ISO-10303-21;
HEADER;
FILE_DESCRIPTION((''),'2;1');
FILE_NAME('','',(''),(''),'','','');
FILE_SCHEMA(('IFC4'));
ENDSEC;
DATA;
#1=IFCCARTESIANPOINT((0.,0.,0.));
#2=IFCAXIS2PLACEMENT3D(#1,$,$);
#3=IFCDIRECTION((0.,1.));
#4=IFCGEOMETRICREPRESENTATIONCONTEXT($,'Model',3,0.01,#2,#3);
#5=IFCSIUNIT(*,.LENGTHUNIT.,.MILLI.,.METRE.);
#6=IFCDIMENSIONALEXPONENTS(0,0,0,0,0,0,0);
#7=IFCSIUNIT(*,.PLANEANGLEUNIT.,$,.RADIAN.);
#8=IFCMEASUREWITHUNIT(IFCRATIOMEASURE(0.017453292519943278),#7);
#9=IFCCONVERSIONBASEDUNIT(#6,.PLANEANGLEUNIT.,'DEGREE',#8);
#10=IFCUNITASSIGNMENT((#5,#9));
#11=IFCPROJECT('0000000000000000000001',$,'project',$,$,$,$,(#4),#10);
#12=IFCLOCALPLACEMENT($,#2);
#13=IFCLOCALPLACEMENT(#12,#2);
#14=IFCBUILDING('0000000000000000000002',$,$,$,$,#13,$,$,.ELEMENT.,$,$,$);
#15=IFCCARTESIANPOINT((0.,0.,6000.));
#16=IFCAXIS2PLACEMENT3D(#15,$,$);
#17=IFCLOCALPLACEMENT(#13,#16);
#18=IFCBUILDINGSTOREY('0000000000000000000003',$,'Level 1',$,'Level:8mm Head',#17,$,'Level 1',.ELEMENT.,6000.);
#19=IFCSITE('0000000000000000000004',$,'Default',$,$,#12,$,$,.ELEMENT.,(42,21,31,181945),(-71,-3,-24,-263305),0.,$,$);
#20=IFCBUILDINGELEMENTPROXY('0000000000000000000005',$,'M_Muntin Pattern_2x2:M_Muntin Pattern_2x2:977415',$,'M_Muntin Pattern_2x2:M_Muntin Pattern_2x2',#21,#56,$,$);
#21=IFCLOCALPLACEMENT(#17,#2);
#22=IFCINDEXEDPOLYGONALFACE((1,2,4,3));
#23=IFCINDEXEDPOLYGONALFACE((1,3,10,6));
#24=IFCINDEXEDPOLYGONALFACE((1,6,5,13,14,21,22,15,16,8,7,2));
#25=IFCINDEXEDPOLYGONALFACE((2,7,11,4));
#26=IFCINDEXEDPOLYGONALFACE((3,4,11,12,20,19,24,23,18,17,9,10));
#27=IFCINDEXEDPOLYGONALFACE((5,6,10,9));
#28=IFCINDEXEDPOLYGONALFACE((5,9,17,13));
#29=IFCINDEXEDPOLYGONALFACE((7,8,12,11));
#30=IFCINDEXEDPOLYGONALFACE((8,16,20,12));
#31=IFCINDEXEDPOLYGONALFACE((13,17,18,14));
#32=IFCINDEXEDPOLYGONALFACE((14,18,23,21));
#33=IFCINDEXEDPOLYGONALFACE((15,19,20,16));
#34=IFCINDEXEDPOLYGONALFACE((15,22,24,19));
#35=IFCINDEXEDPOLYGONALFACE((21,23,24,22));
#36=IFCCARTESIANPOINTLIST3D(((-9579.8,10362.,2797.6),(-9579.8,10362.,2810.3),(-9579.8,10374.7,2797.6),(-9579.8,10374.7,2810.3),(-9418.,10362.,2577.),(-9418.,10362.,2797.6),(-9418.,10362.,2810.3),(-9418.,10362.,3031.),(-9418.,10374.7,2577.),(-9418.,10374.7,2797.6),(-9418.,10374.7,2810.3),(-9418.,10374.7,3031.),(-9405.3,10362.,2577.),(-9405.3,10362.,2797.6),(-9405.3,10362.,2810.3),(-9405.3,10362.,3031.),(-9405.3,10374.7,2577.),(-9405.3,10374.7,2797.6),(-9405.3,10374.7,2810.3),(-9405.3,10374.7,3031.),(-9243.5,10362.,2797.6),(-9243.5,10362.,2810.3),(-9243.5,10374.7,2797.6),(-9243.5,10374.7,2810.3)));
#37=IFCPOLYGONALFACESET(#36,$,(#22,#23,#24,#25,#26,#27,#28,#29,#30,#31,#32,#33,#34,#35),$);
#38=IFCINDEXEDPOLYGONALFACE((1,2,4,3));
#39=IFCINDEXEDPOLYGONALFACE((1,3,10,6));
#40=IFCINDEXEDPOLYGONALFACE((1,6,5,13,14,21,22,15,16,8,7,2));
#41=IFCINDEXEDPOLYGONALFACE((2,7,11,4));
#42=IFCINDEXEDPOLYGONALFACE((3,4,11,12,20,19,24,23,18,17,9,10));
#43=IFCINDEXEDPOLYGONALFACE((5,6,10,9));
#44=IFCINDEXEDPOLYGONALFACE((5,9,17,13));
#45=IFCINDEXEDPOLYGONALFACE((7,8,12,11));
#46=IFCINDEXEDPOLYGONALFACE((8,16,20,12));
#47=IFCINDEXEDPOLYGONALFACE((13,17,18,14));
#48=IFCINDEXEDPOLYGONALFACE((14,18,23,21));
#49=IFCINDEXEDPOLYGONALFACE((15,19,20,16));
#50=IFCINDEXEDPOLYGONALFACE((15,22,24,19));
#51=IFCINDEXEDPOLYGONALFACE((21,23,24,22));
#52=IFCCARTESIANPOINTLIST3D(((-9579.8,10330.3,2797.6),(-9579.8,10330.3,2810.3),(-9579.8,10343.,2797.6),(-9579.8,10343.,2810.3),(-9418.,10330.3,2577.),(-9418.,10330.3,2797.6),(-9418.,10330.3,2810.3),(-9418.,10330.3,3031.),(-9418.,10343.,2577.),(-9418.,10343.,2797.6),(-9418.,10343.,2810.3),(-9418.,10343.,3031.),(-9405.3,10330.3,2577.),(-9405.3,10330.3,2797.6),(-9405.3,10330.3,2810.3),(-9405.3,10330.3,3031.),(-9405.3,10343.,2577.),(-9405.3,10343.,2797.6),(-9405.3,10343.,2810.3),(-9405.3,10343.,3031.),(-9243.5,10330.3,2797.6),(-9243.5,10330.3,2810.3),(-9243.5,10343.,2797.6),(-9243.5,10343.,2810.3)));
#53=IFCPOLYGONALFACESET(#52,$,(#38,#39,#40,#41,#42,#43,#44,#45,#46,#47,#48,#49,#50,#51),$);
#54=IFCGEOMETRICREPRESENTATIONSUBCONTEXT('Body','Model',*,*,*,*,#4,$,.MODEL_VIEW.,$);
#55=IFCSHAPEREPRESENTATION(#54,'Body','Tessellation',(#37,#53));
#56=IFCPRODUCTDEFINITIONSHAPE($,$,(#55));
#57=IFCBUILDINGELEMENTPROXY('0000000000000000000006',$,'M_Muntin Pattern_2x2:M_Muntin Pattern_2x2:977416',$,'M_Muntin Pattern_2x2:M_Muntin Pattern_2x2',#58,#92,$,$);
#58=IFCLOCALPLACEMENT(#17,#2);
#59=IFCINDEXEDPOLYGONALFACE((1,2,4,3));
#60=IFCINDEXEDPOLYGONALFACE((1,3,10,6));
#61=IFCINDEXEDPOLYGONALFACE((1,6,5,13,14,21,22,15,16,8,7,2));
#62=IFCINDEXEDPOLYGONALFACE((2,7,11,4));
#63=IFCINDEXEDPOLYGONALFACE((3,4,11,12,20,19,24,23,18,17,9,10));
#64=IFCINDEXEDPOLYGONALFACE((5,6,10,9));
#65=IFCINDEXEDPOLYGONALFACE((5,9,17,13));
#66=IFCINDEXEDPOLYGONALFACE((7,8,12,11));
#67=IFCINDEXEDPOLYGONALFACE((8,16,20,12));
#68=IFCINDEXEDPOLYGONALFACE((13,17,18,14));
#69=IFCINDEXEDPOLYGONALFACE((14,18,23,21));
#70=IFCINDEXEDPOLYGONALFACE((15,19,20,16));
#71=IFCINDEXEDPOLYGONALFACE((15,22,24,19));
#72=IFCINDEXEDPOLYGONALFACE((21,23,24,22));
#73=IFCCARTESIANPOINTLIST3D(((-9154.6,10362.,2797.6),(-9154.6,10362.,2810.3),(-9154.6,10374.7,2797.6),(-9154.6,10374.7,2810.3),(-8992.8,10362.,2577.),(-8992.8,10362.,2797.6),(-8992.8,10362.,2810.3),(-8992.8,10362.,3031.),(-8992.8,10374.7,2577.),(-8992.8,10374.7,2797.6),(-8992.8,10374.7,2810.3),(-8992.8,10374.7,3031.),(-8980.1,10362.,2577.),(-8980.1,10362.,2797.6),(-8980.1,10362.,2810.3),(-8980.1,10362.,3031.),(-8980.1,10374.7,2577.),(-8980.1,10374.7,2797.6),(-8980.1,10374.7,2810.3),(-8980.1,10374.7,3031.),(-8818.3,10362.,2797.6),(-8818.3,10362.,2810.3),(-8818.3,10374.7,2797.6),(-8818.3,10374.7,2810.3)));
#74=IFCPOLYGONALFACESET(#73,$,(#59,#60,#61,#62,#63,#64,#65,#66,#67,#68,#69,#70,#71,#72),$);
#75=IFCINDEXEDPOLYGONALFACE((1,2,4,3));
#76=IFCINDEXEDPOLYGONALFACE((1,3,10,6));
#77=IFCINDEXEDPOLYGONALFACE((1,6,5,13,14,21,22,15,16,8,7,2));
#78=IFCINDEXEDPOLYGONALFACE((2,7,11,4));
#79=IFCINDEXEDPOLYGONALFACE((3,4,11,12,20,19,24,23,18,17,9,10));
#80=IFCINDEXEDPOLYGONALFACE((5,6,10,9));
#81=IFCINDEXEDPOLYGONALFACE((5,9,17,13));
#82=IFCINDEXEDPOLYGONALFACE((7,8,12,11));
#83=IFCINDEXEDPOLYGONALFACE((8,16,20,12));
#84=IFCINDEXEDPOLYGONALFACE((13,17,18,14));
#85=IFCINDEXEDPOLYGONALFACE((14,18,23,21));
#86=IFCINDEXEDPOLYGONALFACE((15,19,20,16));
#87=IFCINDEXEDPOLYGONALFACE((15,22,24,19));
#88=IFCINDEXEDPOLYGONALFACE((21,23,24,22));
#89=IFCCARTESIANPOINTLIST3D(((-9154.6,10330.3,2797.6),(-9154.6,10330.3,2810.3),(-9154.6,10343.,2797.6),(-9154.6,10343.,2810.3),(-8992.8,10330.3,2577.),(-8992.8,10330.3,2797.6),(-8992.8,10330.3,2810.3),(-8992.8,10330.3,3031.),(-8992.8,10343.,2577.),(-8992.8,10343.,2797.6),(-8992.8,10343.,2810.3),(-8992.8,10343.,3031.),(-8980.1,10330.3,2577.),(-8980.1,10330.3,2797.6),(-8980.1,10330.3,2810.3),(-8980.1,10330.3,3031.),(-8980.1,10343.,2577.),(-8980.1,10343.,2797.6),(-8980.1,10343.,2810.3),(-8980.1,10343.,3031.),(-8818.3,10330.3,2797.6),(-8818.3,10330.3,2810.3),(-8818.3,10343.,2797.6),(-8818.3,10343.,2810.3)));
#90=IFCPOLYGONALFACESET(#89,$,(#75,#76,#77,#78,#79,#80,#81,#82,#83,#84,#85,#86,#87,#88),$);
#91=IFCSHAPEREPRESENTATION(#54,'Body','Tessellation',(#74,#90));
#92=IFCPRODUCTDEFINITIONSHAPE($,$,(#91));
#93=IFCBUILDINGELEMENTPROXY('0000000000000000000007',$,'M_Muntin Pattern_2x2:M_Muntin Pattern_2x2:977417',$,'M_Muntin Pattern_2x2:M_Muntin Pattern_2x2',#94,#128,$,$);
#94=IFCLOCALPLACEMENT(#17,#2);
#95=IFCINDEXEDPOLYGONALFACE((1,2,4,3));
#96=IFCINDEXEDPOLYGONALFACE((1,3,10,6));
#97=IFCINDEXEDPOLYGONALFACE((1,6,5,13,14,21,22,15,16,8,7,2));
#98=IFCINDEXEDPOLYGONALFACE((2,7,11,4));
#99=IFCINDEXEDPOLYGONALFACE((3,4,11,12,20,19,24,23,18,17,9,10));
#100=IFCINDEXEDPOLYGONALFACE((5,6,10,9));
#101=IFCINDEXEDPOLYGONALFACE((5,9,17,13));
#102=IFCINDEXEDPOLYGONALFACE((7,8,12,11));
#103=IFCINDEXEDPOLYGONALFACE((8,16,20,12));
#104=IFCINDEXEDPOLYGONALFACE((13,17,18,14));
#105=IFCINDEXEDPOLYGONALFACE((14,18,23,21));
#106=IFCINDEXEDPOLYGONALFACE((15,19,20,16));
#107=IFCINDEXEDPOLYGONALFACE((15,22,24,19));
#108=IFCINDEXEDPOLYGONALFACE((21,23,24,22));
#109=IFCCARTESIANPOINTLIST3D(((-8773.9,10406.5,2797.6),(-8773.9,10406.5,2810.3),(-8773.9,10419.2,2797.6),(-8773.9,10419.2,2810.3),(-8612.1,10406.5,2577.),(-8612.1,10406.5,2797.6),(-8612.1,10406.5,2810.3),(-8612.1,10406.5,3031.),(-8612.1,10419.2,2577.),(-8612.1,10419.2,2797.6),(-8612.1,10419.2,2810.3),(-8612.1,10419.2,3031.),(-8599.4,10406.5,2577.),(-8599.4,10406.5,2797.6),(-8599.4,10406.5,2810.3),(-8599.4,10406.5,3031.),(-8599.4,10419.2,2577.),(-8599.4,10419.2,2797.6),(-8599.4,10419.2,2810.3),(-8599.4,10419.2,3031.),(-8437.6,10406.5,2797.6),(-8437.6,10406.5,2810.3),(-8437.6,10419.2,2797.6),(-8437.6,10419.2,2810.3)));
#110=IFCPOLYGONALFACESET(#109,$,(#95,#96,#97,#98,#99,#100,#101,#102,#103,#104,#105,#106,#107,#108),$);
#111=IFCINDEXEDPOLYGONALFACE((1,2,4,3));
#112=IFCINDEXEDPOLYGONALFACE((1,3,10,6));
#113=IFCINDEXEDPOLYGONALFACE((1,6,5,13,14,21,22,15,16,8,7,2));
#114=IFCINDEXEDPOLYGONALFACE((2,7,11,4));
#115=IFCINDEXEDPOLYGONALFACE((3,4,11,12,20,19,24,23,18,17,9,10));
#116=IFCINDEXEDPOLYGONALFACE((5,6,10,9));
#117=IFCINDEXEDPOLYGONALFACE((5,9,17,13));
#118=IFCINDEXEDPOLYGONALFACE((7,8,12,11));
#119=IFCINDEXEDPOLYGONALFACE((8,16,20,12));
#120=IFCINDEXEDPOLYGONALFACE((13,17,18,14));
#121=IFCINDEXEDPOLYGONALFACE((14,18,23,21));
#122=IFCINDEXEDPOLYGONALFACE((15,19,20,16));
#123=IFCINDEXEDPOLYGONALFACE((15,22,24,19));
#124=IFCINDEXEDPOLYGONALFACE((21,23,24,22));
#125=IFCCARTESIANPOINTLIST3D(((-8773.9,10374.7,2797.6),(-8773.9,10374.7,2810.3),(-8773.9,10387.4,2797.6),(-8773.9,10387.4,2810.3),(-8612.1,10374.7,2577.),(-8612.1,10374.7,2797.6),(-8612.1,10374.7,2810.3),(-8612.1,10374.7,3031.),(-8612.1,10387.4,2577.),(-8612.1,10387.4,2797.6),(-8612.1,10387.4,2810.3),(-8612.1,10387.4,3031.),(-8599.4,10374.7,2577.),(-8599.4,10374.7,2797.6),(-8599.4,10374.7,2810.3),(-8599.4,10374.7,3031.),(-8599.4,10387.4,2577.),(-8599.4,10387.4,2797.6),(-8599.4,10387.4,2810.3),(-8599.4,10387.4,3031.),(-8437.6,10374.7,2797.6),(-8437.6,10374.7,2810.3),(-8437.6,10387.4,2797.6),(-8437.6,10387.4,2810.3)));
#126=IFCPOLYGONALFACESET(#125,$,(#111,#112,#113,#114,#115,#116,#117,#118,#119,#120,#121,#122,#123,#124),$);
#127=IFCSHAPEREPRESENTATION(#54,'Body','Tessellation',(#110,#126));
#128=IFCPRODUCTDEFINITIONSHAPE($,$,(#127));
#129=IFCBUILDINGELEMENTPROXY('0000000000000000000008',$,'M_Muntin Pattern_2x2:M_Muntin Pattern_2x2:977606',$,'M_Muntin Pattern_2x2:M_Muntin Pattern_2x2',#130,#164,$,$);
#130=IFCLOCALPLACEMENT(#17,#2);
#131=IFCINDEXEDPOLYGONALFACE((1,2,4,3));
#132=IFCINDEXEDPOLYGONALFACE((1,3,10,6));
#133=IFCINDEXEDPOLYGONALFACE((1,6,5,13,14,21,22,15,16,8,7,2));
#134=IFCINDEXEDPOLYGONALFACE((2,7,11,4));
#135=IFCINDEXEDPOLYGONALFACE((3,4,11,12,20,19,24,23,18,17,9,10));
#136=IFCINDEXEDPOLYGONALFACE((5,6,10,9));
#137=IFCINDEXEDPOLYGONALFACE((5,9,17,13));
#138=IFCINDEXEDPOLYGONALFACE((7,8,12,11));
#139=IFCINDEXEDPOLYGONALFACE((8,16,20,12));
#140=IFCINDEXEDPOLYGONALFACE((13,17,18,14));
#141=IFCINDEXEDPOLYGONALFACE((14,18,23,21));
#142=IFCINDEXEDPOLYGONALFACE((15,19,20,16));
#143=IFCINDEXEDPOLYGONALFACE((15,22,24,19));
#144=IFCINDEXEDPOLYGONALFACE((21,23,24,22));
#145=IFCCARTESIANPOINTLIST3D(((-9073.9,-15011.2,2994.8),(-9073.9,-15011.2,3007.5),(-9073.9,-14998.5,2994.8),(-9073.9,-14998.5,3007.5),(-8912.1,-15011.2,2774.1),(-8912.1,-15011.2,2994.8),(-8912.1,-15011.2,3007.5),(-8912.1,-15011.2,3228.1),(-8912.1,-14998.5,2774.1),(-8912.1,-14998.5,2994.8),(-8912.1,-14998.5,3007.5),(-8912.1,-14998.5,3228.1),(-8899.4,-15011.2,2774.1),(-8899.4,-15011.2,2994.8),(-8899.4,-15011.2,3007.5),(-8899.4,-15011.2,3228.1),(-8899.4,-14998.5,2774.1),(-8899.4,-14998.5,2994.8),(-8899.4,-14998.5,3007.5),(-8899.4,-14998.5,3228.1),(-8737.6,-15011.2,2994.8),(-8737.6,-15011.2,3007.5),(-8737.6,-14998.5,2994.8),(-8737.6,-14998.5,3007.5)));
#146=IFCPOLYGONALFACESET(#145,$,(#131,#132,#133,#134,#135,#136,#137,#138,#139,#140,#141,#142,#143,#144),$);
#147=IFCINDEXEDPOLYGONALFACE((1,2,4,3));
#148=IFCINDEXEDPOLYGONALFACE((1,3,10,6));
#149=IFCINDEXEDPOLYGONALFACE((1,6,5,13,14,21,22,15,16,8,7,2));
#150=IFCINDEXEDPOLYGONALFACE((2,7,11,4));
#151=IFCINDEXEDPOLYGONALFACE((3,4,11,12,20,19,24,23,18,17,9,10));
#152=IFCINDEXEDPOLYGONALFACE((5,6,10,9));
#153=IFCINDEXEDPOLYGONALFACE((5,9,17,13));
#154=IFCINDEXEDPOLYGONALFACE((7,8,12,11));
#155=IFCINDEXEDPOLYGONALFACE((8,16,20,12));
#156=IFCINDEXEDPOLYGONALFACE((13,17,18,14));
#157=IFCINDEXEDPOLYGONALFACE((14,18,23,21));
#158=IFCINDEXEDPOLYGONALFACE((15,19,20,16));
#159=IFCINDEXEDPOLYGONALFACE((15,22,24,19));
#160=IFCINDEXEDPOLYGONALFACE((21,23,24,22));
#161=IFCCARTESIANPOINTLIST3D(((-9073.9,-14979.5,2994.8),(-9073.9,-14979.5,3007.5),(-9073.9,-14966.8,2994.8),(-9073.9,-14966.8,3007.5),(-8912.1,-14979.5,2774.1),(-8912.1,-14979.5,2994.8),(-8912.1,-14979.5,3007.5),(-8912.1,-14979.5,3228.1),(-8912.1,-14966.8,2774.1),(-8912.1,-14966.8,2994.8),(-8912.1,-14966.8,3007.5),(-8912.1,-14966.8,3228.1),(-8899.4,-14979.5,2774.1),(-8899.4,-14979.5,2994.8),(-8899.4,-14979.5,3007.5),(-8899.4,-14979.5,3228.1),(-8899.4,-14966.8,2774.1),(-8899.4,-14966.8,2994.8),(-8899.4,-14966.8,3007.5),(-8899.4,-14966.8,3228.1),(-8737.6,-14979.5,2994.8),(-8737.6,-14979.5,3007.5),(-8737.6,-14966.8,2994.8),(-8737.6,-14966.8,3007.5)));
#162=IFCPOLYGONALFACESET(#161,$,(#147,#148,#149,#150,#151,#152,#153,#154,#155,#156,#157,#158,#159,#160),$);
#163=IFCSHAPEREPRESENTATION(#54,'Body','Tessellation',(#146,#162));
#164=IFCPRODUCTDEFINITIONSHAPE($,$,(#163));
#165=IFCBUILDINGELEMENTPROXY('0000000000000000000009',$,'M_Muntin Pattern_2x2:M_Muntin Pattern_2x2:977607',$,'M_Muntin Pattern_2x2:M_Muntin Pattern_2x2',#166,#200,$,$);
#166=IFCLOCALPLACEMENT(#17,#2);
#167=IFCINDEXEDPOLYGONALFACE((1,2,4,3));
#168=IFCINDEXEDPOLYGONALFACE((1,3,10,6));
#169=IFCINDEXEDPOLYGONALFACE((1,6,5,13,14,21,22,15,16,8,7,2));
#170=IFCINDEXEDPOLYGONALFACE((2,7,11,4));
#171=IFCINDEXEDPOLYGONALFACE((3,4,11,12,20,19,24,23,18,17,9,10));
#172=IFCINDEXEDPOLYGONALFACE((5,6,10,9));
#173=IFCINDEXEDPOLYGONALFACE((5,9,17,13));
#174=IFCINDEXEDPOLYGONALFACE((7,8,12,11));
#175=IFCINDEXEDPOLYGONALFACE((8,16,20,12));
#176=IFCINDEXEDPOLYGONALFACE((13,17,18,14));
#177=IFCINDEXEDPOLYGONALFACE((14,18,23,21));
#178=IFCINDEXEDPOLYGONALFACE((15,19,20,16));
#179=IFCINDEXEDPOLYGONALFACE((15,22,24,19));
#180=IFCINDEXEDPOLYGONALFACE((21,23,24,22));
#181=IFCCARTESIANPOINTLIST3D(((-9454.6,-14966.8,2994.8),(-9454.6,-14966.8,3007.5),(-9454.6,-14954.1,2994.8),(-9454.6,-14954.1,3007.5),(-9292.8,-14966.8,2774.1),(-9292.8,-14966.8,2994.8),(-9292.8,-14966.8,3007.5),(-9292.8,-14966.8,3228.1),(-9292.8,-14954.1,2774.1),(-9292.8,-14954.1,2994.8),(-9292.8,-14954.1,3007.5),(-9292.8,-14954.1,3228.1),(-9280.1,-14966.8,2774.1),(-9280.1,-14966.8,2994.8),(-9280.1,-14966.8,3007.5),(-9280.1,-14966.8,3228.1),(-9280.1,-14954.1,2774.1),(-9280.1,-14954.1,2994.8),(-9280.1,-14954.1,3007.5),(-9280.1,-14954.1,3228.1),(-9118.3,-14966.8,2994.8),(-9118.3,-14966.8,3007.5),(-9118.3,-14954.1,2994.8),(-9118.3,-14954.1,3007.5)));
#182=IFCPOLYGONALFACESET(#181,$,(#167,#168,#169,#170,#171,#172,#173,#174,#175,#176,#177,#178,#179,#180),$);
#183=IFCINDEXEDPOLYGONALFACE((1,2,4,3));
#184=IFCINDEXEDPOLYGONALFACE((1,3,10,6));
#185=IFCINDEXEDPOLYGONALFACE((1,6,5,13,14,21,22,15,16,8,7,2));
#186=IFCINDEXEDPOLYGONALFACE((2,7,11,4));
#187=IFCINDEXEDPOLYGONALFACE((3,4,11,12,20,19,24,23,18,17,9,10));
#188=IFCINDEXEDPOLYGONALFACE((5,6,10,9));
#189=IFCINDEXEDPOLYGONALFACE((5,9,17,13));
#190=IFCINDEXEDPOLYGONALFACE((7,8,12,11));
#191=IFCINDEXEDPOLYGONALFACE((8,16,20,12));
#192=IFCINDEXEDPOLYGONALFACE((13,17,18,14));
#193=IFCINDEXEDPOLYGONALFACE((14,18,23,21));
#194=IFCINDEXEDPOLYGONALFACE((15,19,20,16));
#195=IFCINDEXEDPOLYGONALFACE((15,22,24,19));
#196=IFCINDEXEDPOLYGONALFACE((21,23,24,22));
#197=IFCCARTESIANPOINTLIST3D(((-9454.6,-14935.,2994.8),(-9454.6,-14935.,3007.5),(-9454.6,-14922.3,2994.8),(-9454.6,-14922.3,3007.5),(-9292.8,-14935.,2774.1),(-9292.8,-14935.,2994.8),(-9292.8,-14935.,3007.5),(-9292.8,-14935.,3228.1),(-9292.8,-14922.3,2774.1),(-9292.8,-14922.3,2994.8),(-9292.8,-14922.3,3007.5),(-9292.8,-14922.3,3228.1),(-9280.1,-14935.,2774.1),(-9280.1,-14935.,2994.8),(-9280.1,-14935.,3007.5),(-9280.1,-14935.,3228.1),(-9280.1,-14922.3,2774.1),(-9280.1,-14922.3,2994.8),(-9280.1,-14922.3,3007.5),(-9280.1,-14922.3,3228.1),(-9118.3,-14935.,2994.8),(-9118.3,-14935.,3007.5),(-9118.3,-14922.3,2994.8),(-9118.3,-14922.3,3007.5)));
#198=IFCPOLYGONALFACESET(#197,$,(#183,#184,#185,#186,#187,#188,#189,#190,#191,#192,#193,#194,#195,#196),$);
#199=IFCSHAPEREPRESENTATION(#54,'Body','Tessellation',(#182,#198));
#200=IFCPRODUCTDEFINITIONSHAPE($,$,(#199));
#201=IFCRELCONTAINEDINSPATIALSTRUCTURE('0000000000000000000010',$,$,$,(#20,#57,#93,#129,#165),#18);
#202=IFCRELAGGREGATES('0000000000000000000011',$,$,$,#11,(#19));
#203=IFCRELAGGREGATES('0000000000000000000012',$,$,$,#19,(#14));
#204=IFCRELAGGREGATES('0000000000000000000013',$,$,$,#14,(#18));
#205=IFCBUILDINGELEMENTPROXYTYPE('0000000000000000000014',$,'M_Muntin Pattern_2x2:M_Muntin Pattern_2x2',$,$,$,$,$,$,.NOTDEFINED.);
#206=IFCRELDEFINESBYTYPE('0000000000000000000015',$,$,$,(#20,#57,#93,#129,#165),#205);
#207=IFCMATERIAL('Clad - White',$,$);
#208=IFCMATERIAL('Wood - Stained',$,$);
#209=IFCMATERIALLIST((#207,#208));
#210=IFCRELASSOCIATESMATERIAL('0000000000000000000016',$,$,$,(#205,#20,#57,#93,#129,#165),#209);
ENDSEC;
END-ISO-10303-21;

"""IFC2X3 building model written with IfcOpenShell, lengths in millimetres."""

from ifc_helpers import new_model, entity, si_unit, converted_unit, direction, frame, origin, place, context, subcontext, project, spatial, polyline, outline, extrude, source, transform, mapped, material, material_list, type_object, type_shapes, element, save


model = new_model("IFC2X3")

# Units and contexts
model_context = context("Model", 3, precision=0.01, world=origin(), true_north=direction((0.0, 1.0)))
body_context = subcontext(model_context, "Body", "Model", "MODEL_VIEW")
ifc_project = project(units=[si_unit("LENGTHUNIT", "METRE", prefix="MILLI"), converted_unit("PLANEANGLEUNIT", "DEGREE", entity("IfcRatioMeasure", 0.017453292519943278), si_unit("PLANEANGLEUNIT", "RADIAN"), dimensions=[0, 0, 0, 0, 0, 0, 0])], contexts=[model_context])

# Site, building, storey
site_placement = place(None, origin())
site = spatial("IfcSite", under=ifc_project, at=site_placement, Name="Default", CompositionType="ELEMENT", RefLatitude=(42, 21, 31, 181945), RefLongitude=(-71, -3, -24, -263305), RefElevation=0.0)
building_placement = place(site_placement, origin())
building = spatial("IfcBuilding", under=site, at=building_placement, CompositionType="ELEMENT")
storey_placement = place(building_placement, frame((0.0, 0.0, 6000.0)))
storey = spatial("IfcBuildingStorey", under=building, at=storey_placement, Name="Level 1", ObjectType="Level:8mm Head", LongName="Level 1", CompositionType="ELEMENT", Elevation=6000.0)

# Building element proxies
ifc_material_1 = material(Name="Clad - White")
ifc_material_2 = material(Name="Wood - Stained")
ifc_material_list_1 = material_list([ifc_material_1, ifc_material_2])
building_element_proxy_type_1 = type_object("IfcBuildingElementProxyType", Name="M_Muntin Pattern_2x2:M_Muntin Pattern_2x2", PredefinedType="NOTDEFINED", material=ifc_material_list_1)
shared_shape_1 = source(origin(), body_context, "Body", "SweptSolid", [
    extrude(outline(polyline([(6.4, -6.4), (227.0, -6.4), (227.0, 6.3), (6.4, 6.3), (6.4, 168.2), (-6.3, 168.2), (-6.3, 6.3), (-227.0, 6.3), (-227.0, -6.4), (-6.3, -6.4), (-6.3, -168.1), (6.4, -168.1), (6.4, -6.4)])), frame((0.0, 9.5, 227.0), z_axis=(0.0, 1.0, 0.0), x_axis=(0.0, 0.0, 1.0)), (0.0, 0.0, 1.0), 12.7),
    extrude(outline(polyline([(6.4, -6.4), (227.0, -6.4), (227.0, 6.3), (6.4, 6.3), (6.4, 168.2), (-6.3, 168.2), (-6.3, 6.3), (-227.0, 6.3), (-227.0, -6.4), (-6.3, -6.4), (-6.3, -168.1), (6.4, -168.1), (6.4, -6.4)])), frame((0.0, -22.2, 227.0), z_axis=(0.0, 1.0, 0.0), x_axis=(0.0, 0.0, 1.0)), (0.0, 0.0, 1.0), 12.7),
])
type_shapes(building_element_proxy_type_1, [shared_shape_1])
for number, where, name in (
    (1, (-9411.7, 10352.5, 2577.0), "M_Muntin Pattern_2x2:M_Muntin Pattern_2x2:977415"),
    (2, (-8986.5, 10352.5, 2577.0), "M_Muntin Pattern_2x2:M_Muntin Pattern_2x2:977416"),
    (3, (-8605.7, 10396.9, 2577.0), "M_Muntin Pattern_2x2:M_Muntin Pattern_2x2:977417"),
):
    element("IfcBuildingElementProxy", number, at=place(storey_placement, frame(where)), inside=storey, type_object=building_element_proxy_type_1, material=ifc_material_list_1, Name=name, ObjectType="M_Muntin Pattern_2x2:M_Muntin Pattern_2x2", context=body_context, shape_type="MappedRepresentation", body=[
        mapped(shared_shape_1, transform((0.0, 0.0, 0.0), scale=1.0)),
    ])
for number, where, z_axis, x_axis, name in (
    (4, (-8905.7, -14989.0, 2774.1), (0.0, 0.0, 1.0), (-1.0, 0.0, 0.0), "M_Muntin Pattern_2x2:M_Muntin Pattern_2x2:977606"),
    (5, (-9286.5, -14944.6, 2774.1), (0.0, 0.0, 1.0), (-1.0, 0.0, 0.0), "M_Muntin Pattern_2x2:M_Muntin Pattern_2x2:977607"),
):
    element("IfcBuildingElementProxy", number, at=place(storey_placement, frame(where, z_axis=z_axis, x_axis=x_axis)), inside=storey, type_object=building_element_proxy_type_1, material=ifc_material_list_1, Name=name, ObjectType="M_Muntin Pattern_2x2:M_Muntin Pattern_2x2", context=body_context, shape_type="MappedRepresentation", body=[
        mapped(shared_shape_1, transform((0.0, 0.0, 0.0), scale=1.0)),
    ])

save(model, "model.ifc")
